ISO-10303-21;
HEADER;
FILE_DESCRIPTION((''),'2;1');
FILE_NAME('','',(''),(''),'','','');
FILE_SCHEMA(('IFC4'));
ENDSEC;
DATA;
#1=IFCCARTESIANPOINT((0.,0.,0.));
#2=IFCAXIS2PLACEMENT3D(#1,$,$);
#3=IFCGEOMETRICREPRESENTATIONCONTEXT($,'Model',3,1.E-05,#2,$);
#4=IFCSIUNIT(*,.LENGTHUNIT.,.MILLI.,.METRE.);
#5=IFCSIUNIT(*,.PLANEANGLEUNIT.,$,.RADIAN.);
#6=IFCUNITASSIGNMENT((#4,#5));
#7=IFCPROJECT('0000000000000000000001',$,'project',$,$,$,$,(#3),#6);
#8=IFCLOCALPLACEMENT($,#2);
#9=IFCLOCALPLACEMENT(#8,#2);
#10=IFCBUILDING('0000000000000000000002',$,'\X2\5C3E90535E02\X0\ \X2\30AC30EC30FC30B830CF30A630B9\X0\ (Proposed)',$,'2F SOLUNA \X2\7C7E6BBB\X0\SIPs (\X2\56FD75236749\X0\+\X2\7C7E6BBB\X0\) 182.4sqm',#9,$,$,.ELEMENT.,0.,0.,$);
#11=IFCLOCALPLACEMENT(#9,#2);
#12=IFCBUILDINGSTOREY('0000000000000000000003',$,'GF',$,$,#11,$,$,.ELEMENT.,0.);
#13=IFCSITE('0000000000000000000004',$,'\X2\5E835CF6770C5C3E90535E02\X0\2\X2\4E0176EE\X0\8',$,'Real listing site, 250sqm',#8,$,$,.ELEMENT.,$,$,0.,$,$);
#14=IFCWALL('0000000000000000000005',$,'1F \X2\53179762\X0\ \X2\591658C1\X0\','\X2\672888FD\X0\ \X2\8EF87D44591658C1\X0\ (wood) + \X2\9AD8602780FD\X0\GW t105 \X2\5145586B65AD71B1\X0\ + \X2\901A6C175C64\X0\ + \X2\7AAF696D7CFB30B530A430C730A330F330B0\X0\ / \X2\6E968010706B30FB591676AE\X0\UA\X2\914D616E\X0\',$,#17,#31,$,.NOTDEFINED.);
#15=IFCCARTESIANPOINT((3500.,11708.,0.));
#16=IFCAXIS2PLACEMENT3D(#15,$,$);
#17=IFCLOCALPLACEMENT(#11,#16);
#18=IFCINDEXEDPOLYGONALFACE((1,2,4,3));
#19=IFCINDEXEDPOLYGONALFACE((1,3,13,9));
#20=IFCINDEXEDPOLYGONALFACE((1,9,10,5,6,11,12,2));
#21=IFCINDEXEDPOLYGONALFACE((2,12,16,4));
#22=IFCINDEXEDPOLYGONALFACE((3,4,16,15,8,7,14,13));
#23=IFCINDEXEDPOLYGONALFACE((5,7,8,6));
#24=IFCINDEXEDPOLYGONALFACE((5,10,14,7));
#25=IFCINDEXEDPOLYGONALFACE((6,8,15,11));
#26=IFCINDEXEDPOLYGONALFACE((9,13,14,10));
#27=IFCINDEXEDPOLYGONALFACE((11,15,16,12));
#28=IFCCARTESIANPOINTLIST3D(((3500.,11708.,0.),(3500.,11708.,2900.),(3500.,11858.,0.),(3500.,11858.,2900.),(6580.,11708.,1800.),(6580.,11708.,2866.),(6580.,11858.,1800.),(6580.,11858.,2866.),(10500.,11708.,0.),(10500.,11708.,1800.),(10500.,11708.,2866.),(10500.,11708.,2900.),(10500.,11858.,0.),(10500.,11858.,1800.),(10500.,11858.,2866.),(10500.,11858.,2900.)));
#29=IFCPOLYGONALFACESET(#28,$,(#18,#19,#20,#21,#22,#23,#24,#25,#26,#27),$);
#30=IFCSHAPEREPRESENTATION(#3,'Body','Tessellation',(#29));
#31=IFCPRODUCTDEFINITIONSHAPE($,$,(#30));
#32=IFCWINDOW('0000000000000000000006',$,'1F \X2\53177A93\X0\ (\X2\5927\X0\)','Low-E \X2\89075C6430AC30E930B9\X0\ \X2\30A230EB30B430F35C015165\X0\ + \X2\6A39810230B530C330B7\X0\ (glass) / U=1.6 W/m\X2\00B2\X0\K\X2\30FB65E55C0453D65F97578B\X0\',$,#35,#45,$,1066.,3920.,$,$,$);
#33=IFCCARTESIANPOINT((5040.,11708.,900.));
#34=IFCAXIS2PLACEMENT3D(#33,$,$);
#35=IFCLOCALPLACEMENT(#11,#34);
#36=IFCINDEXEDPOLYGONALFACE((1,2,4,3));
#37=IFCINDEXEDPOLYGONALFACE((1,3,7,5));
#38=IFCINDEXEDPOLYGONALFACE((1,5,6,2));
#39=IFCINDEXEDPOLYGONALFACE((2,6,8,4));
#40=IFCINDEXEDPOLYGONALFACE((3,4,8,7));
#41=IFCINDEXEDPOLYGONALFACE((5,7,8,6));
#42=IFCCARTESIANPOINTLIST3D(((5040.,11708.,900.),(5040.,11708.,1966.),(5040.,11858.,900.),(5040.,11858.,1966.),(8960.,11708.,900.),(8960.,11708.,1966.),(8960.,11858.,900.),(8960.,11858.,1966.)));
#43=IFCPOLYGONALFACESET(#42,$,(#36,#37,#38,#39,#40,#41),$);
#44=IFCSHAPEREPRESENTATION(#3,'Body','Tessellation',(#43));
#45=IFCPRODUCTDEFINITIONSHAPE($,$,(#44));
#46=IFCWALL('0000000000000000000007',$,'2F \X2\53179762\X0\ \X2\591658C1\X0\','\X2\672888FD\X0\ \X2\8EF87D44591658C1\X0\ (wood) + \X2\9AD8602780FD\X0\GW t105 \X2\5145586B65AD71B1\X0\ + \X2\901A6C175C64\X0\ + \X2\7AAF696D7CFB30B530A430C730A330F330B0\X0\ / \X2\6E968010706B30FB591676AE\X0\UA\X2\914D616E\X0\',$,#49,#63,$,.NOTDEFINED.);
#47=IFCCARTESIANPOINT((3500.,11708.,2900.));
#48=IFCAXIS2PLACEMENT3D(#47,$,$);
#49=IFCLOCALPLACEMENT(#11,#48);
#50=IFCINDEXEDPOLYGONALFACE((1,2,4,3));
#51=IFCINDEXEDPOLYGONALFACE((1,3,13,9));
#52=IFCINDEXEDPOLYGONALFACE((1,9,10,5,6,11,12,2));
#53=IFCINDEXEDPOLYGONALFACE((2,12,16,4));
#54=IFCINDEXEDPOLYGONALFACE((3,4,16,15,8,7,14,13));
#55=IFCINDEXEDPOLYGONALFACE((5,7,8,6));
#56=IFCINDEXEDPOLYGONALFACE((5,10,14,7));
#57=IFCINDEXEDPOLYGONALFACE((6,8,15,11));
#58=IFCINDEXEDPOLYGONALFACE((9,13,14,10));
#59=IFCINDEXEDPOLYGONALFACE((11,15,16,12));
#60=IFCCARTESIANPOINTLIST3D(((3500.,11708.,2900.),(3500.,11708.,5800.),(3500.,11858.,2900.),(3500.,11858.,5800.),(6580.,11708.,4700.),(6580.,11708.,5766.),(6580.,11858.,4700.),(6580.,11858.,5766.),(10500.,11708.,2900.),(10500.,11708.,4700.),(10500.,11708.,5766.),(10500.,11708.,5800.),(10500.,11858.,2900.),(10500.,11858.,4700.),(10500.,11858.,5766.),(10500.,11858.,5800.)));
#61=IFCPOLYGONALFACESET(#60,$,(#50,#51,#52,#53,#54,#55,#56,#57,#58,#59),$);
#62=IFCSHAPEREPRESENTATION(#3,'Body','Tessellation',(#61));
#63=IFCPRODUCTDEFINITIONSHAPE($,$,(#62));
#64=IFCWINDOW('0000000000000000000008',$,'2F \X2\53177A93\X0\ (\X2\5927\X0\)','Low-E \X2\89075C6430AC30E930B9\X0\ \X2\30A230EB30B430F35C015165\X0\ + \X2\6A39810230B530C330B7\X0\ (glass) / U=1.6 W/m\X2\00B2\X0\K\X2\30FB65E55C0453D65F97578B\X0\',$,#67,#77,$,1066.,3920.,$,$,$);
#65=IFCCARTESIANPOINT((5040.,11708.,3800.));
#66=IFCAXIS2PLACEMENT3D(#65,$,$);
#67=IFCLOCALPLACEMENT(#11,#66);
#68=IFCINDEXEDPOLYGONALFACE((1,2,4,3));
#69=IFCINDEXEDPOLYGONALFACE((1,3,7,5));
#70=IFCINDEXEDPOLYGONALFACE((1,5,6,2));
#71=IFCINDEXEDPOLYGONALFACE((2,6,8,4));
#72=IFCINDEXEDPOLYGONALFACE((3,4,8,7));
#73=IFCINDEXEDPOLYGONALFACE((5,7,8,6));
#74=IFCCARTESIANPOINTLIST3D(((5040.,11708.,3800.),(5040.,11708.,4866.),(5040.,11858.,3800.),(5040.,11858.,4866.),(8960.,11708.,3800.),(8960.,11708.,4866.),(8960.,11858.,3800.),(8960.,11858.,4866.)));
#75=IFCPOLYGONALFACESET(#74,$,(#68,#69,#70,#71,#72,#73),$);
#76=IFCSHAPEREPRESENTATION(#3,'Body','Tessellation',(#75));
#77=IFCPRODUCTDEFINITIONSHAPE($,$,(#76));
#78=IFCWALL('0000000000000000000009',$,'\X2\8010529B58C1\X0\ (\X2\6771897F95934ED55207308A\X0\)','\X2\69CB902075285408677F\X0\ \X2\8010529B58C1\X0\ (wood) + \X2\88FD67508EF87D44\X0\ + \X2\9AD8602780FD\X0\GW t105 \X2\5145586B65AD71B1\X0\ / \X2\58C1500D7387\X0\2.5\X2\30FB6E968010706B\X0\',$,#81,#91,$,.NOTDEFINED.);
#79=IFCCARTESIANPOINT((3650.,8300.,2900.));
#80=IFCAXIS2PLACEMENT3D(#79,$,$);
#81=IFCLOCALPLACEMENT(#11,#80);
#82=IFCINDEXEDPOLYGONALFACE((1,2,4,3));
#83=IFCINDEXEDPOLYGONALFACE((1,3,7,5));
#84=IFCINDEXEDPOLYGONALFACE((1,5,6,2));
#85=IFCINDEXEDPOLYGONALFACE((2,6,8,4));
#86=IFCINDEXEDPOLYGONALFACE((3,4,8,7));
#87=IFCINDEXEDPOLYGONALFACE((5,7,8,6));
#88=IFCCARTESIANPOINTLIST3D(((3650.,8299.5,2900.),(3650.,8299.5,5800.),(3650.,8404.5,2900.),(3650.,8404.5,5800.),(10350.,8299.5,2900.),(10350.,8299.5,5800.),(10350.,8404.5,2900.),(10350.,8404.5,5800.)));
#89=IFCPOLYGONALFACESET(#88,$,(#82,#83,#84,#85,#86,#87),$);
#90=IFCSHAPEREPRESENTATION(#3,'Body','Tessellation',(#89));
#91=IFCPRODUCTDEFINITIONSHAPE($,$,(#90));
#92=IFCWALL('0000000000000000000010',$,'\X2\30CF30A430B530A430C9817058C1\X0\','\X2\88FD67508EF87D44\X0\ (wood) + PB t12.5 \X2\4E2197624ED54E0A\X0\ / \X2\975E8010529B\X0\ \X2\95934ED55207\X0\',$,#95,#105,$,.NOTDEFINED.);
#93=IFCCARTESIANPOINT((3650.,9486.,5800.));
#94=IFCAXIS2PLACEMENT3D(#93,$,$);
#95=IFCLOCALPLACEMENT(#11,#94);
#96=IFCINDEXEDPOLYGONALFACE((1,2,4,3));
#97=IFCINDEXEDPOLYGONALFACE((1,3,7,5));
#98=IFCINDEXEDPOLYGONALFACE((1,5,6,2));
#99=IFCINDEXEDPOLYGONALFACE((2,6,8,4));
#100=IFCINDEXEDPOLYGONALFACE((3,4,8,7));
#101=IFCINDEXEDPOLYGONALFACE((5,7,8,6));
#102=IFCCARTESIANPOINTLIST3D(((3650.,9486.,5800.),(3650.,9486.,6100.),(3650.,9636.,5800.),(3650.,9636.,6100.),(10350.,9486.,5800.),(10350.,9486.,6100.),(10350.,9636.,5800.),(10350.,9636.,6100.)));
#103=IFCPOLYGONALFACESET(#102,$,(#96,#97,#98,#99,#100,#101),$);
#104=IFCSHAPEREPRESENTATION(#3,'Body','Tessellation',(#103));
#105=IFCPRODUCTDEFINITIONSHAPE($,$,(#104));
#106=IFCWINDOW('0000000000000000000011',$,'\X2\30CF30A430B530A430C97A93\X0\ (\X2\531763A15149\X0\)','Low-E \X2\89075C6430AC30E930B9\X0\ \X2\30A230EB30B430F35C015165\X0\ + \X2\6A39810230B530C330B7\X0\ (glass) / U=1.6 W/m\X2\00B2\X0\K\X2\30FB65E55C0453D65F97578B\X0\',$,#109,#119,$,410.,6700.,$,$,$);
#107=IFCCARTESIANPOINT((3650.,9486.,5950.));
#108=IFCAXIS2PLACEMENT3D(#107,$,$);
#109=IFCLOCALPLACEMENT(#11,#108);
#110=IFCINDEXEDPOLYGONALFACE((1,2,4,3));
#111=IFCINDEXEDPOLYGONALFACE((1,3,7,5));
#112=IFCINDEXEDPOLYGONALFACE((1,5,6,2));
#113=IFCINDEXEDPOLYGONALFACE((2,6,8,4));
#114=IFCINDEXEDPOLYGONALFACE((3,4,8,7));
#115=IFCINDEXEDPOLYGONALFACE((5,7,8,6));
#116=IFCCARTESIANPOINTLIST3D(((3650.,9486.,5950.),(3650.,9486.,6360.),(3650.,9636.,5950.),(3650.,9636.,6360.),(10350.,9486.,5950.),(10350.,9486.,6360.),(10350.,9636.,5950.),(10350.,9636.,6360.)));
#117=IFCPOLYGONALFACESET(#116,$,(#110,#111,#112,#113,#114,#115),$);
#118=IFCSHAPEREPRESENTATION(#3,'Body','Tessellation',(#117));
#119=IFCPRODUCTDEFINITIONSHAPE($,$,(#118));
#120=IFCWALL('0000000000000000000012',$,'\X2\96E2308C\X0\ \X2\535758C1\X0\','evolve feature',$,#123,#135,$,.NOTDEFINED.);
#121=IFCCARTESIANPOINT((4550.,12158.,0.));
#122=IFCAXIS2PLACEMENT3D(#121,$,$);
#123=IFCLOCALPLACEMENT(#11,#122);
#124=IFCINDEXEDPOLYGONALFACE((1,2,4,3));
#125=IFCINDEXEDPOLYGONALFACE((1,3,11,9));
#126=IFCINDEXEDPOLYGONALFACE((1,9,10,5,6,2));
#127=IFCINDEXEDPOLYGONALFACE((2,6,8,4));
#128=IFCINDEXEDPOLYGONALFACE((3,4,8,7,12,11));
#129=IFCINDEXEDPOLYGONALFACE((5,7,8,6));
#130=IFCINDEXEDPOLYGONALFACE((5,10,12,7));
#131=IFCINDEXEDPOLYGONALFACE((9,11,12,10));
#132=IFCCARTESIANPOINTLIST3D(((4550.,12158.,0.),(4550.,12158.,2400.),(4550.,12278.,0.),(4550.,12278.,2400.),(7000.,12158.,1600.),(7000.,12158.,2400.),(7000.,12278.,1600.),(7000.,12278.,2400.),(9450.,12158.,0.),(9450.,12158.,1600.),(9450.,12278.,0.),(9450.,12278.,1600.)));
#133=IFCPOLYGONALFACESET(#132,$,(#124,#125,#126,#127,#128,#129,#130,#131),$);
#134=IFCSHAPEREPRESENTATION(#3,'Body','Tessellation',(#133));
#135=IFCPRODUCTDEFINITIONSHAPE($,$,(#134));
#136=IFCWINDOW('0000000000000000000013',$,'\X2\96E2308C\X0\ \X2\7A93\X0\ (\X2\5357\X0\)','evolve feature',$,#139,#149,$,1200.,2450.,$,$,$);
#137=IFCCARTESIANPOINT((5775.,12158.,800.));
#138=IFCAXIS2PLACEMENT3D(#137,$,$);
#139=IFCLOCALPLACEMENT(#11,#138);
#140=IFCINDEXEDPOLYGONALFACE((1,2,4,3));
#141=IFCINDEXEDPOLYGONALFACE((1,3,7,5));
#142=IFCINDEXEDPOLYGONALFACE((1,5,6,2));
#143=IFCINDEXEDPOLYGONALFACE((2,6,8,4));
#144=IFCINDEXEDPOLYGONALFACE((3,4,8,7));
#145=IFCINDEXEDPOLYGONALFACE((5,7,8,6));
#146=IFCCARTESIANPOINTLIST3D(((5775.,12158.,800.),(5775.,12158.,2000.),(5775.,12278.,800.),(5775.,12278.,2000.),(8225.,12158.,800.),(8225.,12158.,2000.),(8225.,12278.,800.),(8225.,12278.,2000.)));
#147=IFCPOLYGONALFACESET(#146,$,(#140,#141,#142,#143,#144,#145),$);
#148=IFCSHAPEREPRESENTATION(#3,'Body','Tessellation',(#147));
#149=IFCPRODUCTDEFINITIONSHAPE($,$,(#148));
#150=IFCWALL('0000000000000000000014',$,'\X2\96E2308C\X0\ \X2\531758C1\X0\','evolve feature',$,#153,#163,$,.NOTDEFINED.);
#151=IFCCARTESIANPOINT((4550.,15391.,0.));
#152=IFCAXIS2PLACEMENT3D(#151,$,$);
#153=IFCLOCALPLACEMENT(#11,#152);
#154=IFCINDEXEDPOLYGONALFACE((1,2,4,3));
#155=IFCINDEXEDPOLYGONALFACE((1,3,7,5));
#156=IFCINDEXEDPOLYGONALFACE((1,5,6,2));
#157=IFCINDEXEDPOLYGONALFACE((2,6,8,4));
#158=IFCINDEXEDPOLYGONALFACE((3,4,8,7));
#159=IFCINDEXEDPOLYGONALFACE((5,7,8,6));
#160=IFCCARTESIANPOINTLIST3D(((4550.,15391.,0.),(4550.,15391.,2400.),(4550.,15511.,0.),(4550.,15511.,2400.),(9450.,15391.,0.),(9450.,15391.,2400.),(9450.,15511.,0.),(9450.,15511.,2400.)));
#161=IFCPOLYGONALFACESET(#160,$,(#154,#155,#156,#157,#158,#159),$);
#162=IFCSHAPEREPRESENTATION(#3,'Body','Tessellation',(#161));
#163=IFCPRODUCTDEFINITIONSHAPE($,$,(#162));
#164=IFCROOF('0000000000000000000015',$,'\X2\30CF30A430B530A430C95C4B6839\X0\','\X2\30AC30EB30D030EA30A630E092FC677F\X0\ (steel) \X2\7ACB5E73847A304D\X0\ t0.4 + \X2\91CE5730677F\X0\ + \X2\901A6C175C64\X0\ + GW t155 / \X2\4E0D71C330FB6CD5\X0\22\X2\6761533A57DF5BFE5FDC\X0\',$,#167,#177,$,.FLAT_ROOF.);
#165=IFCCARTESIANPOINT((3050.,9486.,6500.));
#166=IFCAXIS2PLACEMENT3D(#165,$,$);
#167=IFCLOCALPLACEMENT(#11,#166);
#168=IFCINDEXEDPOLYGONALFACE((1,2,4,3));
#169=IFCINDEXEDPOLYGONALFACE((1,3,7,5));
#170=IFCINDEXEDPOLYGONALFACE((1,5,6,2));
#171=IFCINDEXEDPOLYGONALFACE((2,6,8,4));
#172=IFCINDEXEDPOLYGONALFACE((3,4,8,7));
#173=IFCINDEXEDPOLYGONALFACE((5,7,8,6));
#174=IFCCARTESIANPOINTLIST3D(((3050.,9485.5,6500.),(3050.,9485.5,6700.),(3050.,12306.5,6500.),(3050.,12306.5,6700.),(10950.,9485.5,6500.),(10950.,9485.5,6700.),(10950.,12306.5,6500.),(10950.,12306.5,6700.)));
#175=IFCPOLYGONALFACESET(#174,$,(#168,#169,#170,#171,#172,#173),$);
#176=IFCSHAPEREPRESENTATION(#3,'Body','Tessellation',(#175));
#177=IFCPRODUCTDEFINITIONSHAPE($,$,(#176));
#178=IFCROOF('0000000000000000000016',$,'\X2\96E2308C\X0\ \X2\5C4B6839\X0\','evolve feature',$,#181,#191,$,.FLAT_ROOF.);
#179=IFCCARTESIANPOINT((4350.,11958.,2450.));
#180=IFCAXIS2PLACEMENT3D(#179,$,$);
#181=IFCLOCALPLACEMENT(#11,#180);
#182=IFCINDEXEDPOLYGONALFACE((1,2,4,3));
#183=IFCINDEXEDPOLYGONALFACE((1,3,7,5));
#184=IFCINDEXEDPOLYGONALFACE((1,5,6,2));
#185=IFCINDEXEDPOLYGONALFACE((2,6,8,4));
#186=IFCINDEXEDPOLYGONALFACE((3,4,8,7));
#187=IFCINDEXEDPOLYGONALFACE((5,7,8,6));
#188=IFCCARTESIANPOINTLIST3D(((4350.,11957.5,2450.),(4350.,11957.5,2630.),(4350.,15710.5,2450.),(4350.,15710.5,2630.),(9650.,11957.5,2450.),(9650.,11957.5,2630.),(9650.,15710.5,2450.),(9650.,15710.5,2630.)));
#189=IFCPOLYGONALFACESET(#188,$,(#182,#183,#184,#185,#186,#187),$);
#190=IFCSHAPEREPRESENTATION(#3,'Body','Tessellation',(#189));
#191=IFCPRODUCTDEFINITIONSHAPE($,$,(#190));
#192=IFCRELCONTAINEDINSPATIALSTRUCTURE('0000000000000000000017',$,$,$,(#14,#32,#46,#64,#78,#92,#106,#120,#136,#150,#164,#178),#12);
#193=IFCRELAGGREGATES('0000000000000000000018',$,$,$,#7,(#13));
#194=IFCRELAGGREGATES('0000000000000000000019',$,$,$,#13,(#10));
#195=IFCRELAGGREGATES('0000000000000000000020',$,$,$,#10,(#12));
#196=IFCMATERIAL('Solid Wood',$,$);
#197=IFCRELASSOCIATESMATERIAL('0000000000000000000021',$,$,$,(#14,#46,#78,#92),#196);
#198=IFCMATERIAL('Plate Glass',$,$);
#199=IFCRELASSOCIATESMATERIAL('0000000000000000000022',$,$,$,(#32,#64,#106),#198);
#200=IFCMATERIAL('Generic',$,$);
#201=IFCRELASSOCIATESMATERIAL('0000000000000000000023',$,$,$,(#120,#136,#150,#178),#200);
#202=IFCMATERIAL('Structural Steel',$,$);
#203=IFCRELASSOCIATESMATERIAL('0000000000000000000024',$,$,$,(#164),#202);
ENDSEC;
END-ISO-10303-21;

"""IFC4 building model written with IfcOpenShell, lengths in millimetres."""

from ifc_helpers import new_model, si_unit, frame, frame_2d, origin, place, context, project, spatial, rectangle, extrude, material, element, fill, save


model = new_model("IFC4")

# Units and contexts
model_context = context("Model", 3, precision=1e-05, world=origin())
ifc_project = project(units=[si_unit("LENGTHUNIT", "METRE", prefix="MILLI"), si_unit("PLANEANGLEUNIT", "RADIAN")], contexts=[model_context])

# Site, building, storey
site_placement = place(None, origin())
site = spatial("IfcSite", under=ifc_project, at=site_placement, Name="広島県尾道市2丁目8", ObjectType="Real listing site, 250sqm", CompositionType="ELEMENT", RefElevation=0.0)
building_placement = place(site_placement, origin())
building = spatial("IfcBuilding", under=site, at=building_placement, Name="尾道市 ガレージハウス (Proposed)", ObjectType="2F SOLUNA 籾殻SIPs (国産杉+籾殻) 182.4sqm", CompositionType="ELEMENT", ElevationOfRefHeight=0.0, ElevationOfTerrain=0.0)
storey_placement = place(building_placement, origin())
storey = spatial("IfcBuildingStorey", under=building, at=storey_placement, Name="GF", CompositionType="ELEMENT", Elevation=0.0)

# Shared definitions
ifc_material_1 = material(Name="Generic")

# Wall, opening, window
ifc_material_2 = material(Name="Solid Wood")
wall_1_placement = place(storey_placement, frame((3500.0, 11708.0, 0.0)))
wall_1 = element("IfcWall", 1, at=wall_1_placement, inside=storey, material=ifc_material_2, Name="1F 北面 外壁", Description="木製 軸組外壁 (wood) + 高性能GW t105 充填断熱 + 通気層 + 窯業系サイディング / 準耐火・外皮UA配慮", PredefinedType="NOTDEFINED", context=model_context, shape_type="SweptSolid", body=[
    extrude(rectangle(XDim=7000.0, YDim=150.0, at=frame_2d((3500.0, 75.0))), frame((3500.0, 11708.0, 0.0)), (0.0, 0.0, 1.0), 2900.0),
])
opening_1_placement = place(storey_placement, frame((5040.0, 11708.0, 900.0)))
opening_1 = element("IfcOpeningElement", 2, at=opening_1_placement, cuts=wall_1, PredefinedType="NOTDEFINED", context=model_context, shape_type="SweptSolid", body=[
    extrude(rectangle(XDim=3920.0, YDim=150.0, at=frame_2d((1960.0, 75.0))), frame((5040.0, 11708.0, 900.0)), (0.0, 0.0, 1.0), 1066.0),
])
ifc_material_3 = material(Name="Plate Glass")
window_1_placement = place(storey_placement, frame((5040.0, 11708.0, 900.0)))
window_1 = element("IfcWindow", 3, at=window_1_placement, inside=storey, material=ifc_material_3, Name="1F 北窓 (大)", Description="Low-E 複層ガラス アルゴン封入 + 樹脂サッシ (glass) / U=1.6 W/m²K・日射取得型", OverallHeight=1066.0, OverallWidth=3920.0, context=model_context, shape_type="SweptSolid", body=[
    extrude(rectangle(XDim=3920.0, YDim=150.0, at=frame_2d((1960.0, 75.0))), frame((5040.0, 11708.0, 900.0)), (0.0, 0.0, 1.0), 1066.0),
])
fill(opening_1, window_1)

# Wall, opening, window
wall_2_placement = place(storey_placement, frame((3500.0, 11708.0, 2900.0)))
wall_2 = element("IfcWall", 4, at=wall_2_placement, inside=storey, material=ifc_material_2, Name="2F 北面 外壁", Description="木製 軸組外壁 (wood) + 高性能GW t105 充填断熱 + 通気層 + 窯業系サイディング / 準耐火・外皮UA配慮", PredefinedType="NOTDEFINED", context=model_context, shape_type="SweptSolid", body=[
    extrude(rectangle(XDim=7000.0, YDim=150.0, at=frame_2d((3500.0, 75.0))), frame((3500.0, 11708.0, 2900.0)), (0.0, 0.0, 1.0), 2900.0),
])
opening_2_placement = place(storey_placement, frame((5040.0, 11708.0, 3800.0)))
opening_2 = element("IfcOpeningElement", 5, at=opening_2_placement, cuts=wall_2, PredefinedType="NOTDEFINED", context=model_context, shape_type="SweptSolid", body=[
    extrude(rectangle(XDim=3920.0, YDim=150.0, at=frame_2d((1960.0, 75.0))), frame((5040.0, 11708.0, 3800.0)), (0.0, 0.0, 1.0), 1066.0),
])
window_2_placement = place(storey_placement, frame((5040.0, 11708.0, 3800.0)))
window_2 = element("IfcWindow", 6, at=window_2_placement, inside=storey, material=ifc_material_3, Name="2F 北窓 (大)", Description="Low-E 複層ガラス アルゴン封入 + 樹脂サッシ (glass) / U=1.6 W/m²K・日射取得型", OverallHeight=1066.0, OverallWidth=3920.0, context=model_context, shape_type="SweptSolid", body=[
    extrude(rectangle(XDim=3920.0, YDim=150.0, at=frame_2d((1960.0, 75.0))), frame((5040.0, 11708.0, 3800.0)), (0.0, 0.0, 1.0), 1066.0),
])
fill(opening_2, window_2)

# Wall
wall_3_placement = place(storey_placement, frame((3650.0, 8300.0, 2900.0)))
element("IfcWall", 7, at=wall_3_placement, inside=storey, material=ifc_material_2, Name="耐力壁 (東西間仕切り)", Description="構造用合板 耐力壁 (wood) + 製材軸組 + 高性能GW t105 充填断熱 / 壁倍率2.5・準耐火", PredefinedType="NOTDEFINED", context=model_context, shape_type="SweptSolid", body=[
    extrude(rectangle(XDim=6700.0, YDim=105.0, at=frame_2d((3350.0, 52.0))), frame((3650.0, 8300.0, 2900.0)), (0.0, 0.0, 1.0), 2900.0),
])

# Walls, openings, windows
wall_4_placement = place(storey_placement, frame((3650.0, 9486.0, 5800.0)))
wall_4 = element("IfcWall", 8, at=wall_4_placement, inside=storey, material=ifc_material_2, Name="ハイサイド腰壁", Description="製材軸組 (wood) + PB t12.5 両面仕上 / 非耐力 間仕切", PredefinedType="NOTDEFINED", context=model_context, shape_type="SweptSolid", body=[
    extrude(rectangle(XDim=6700.0, YDim=150.0, at=frame_2d((3350.0, 75.0))), frame((3650.0, 9486.0, 5800.0)), (0.0, 0.0, 1.0), 700.0),
])
opening_3_placement = place(storey_placement, frame((3650.0, 9486.0, 5950.0)))
opening_3 = element("IfcOpeningElement", 9, at=opening_3_placement, cuts=wall_4, PredefinedType="NOTDEFINED", context=model_context, shape_type="SweptSolid", body=[
    extrude(rectangle(XDim=6700.0, YDim=150.0, at=frame_2d((3350.0, 75.0))), frame((3650.0, 9486.0, 5950.0)), (0.0, 0.0, 1.0), 410.0),
])
window_3_placement = place(storey_placement, frame((3650.0, 9486.0, 5950.0)))
window_3 = element("IfcWindow", 10, at=window_3_placement, inside=storey, material=ifc_material_3, Name="ハイサイド窓 (北採光)", Description="Low-E 複層ガラス アルゴン封入 + 樹脂サッシ (glass) / U=1.6 W/m²K・日射取得型", OverallHeight=410.0, OverallWidth=6700.0, context=model_context, shape_type="SweptSolid", body=[
    extrude(rectangle(XDim=6700.0, YDim=150.0, at=frame_2d((3350.0, 75.0))), frame((3650.0, 9486.0, 5950.0)), (0.0, 0.0, 1.0), 410.0),
])
fill(opening_3, window_3)
wall_5_placement = place(storey_placement, frame((4550.0, 12158.0, 0.0)))
wall_5 = element("IfcWall", 11, at=wall_5_placement, inside=storey, material=ifc_material_1, Name="離れ 南壁", Description="evolve feature", PredefinedType="NOTDEFINED", context=model_context, shape_type="SweptSolid", body=[
    extrude(rectangle(XDim=4900.0, YDim=120.0, at=frame_2d((2450.0, 60.0))), frame((4550.0, 12158.0, 0.0)), (0.0, 0.0, 1.0), 2400.0),
])
opening_4_placement = place(storey_placement, frame((5775.0, 12158.0, 800.0)))
opening_4 = element("IfcOpeningElement", 12, at=opening_4_placement, cuts=wall_5, PredefinedType="NOTDEFINED", context=model_context, shape_type="SweptSolid", body=[
    extrude(rectangle(XDim=2450.0, YDim=120.0, at=frame_2d((1225.0, 60.0))), frame((5775.0, 12158.0, 800.0)), (0.0, 0.0, 1.0), 1200.0),
])
window_4_placement = place(storey_placement, frame((5775.0, 12158.0, 800.0)))
window_4 = element("IfcWindow", 13, at=window_4_placement, inside=storey, material=ifc_material_1, Name="離れ 窓 (南)", Description="evolve feature", OverallHeight=1200.0, OverallWidth=2450.0, context=model_context, shape_type="SweptSolid", body=[
    extrude(rectangle(XDim=2450.0, YDim=120.0, at=frame_2d((1225.0, 60.0))), frame((5775.0, 12158.0, 800.0)), (0.0, 0.0, 1.0), 1200.0),
])
fill(opening_4, window_4)

# Wall
wall_6_placement = place(storey_placement, frame((4550.0, 15391.0, 0.0)))
element("IfcWall", 14, at=wall_6_placement, inside=storey, material=ifc_material_1, Name="離れ 北壁", Description="evolve feature", PredefinedType="NOTDEFINED", context=model_context, shape_type="SweptSolid", body=[
    extrude(rectangle(XDim=4900.0, YDim=120.0, at=frame_2d((2450.0, 60.0))), frame((4550.0, 15391.0, 0.0)), (0.0, 0.0, 1.0), 2400.0),
])

# Roofs
ifc_material_4 = material(Name="Structural Steel")
roof_1_placement = place(storey_placement, frame((3050.0, 9486.0, 6500.0)))
element("IfcRoof", 15, at=roof_1_placement, inside=storey, material=ifc_material_4, Name="ハイサイド屋根", Description="ガルバリウム鋼板 (steel) 立平葺き t0.4 + 野地板 + 通気層 + GW t155 / 不燃・法22条区域対応", PredefinedType="FLAT_ROOF", context=model_context, shape_type="SweptSolid", body=[
    extrude(rectangle(XDim=7900.0, YDim=2821.0, at=frame_2d((3950.0, 1410.0))), frame((3050.0, 9486.0, 6500.0)), (0.0, 0.0, 1.0), 200.0),
])
roof_2_placement = place(storey_placement, frame((4350.0, 11958.0, 2450.0)))
element("IfcRoof", 16, at=roof_2_placement, inside=storey, material=ifc_material_1, Name="離れ 屋根", Description="evolve feature", PredefinedType="FLAT_ROOF", context=model_context, shape_type="SweptSolid", body=[
    extrude(rectangle(XDim=5300.0, YDim=3753.0, at=frame_2d((2650.0, 1876.0))), frame((4350.0, 11958.0, 2450.0)), (0.0, 0.0, 1.0), 180.0),
])

save(model, "model.ifc")
